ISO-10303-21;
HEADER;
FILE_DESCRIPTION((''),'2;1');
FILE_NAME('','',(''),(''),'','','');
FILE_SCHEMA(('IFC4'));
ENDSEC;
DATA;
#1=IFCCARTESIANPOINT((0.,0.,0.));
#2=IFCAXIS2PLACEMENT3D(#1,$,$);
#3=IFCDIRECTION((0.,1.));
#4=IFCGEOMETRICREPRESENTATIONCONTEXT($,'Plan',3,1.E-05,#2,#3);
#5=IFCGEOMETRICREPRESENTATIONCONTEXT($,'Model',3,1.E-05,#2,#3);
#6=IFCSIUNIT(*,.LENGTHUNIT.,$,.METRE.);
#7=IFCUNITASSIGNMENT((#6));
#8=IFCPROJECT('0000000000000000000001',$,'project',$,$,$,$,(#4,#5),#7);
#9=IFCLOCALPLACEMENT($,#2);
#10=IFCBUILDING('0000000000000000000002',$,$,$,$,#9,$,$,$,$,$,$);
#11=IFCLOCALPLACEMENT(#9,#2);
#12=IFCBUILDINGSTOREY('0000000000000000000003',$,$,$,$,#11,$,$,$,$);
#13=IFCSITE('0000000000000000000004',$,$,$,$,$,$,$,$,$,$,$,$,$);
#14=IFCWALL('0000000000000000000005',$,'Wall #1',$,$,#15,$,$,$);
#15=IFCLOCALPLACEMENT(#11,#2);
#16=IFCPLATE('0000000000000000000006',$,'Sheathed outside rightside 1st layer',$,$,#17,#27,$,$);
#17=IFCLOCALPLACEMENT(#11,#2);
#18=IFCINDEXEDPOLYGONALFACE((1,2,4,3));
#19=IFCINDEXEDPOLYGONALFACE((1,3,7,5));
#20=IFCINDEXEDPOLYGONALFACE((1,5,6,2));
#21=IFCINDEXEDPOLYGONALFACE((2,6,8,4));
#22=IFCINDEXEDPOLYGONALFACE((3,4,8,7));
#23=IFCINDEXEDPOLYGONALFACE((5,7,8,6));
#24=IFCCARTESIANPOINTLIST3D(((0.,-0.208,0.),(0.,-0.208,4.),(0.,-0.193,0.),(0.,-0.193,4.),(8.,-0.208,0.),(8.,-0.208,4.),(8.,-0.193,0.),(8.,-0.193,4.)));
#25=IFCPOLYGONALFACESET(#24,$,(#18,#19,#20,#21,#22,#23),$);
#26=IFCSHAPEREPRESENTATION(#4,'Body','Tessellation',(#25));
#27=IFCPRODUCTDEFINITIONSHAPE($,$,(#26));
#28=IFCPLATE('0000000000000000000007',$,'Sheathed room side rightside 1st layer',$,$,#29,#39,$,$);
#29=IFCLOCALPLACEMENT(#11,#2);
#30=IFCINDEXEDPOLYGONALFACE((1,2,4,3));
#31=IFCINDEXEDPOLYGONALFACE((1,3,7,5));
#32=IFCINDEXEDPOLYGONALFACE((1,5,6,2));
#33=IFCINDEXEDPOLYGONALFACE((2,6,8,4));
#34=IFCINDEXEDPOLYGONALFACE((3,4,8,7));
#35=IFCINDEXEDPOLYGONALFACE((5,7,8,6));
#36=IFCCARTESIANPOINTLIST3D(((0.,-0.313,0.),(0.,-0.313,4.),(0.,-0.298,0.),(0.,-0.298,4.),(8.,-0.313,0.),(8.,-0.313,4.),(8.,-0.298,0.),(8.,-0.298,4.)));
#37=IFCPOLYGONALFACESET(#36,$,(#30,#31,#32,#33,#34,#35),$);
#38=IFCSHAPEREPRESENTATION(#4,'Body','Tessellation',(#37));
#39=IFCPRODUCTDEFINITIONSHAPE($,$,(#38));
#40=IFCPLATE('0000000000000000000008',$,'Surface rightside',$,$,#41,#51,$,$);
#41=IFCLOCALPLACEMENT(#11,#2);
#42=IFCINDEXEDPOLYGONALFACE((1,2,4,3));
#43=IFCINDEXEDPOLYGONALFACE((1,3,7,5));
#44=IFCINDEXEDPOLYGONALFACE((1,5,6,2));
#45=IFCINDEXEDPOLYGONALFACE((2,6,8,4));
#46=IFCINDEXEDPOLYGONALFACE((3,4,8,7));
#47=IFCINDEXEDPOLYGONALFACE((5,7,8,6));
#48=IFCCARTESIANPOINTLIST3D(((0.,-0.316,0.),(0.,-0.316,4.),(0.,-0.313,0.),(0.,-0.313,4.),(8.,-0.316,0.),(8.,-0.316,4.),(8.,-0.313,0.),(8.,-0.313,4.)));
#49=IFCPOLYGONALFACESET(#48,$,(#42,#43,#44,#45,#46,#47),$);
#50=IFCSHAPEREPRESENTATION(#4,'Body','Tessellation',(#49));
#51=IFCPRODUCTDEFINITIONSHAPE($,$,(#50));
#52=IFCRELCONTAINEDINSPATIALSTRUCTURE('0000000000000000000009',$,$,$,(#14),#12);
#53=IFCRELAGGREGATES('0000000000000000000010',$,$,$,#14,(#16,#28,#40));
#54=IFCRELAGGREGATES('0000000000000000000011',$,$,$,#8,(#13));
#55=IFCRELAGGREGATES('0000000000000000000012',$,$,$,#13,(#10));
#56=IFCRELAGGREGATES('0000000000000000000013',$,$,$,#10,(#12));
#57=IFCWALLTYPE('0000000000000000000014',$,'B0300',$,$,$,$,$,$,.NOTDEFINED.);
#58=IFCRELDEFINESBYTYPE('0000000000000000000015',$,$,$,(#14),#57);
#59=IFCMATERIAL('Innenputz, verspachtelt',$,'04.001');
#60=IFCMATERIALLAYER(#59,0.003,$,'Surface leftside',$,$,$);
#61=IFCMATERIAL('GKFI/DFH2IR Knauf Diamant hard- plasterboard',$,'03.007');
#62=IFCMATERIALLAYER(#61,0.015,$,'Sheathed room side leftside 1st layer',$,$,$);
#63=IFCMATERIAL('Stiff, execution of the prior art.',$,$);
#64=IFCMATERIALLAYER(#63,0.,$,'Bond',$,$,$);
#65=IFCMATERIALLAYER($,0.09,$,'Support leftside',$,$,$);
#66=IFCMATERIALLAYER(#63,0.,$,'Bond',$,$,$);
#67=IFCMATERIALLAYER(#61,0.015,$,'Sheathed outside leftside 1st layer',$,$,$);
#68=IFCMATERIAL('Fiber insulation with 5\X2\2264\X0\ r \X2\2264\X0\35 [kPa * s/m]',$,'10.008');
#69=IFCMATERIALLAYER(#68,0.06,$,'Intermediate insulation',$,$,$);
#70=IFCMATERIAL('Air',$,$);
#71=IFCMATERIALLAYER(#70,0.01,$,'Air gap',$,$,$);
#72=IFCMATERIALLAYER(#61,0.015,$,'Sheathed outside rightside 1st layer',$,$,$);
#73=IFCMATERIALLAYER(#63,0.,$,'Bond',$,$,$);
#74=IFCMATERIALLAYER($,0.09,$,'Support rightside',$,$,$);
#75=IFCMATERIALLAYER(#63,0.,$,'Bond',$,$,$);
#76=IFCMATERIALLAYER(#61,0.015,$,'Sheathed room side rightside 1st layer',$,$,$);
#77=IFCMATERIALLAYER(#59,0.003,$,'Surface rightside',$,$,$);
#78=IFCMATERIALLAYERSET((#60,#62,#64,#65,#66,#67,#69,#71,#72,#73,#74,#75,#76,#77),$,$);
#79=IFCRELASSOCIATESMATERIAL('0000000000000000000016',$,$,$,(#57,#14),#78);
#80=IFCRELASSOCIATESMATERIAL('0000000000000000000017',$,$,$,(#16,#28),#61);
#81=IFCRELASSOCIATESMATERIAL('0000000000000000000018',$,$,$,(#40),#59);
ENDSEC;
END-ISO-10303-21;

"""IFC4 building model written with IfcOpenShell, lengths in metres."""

from ifc_helpers import new_model, si_unit, direction, frame, frame_2d, origin, place, context, project, spatial, rectangle, extrude, material, layer, layer_set, type_object, element, aggregate, save


model = new_model("IFC4")

# Units and contexts
plan_context = context("Plan", 3, precision=1e-05, world=origin(), true_north=direction((0.0, 1.0)))
model_context = context("Model", 3, precision=1e-05, world=origin(), true_north=direction((0.0, 1.0)))
ifc_project = project(units=[si_unit("LENGTHUNIT", "METRE")], contexts=[plan_context, model_context])

# Site, building, storey
site = spatial("IfcSite", under=ifc_project)
building_placement = place(None, origin())
building = spatial("IfcBuilding", under=site, at=building_placement)
storey_placement = place(building_placement, origin())
storey = spatial("IfcBuildingStorey", under=building, at=storey_placement)

# Wall, plates
ifc_material_1 = material(Name="Innenputz, verspachtelt", Category="04.001")
ifc_layer_1 = layer(ifc_material_1, 0.003, Name="Surface leftside")
ifc_material_2 = material(Name="GKFI/DFH2IR Knauf Diamant hard- plasterboard", Category="03.007")
ifc_layer_2 = layer(ifc_material_2, 0.015, Name="Sheathed room side leftside 1st layer")
ifc_material_3 = material(Name="Stiff, execution of the prior art.")
ifc_layer_3 = layer(ifc_material_3, 0.0, Name="Bond")
ifc_layer_4 = layer(None, 0.09, Name="Support leftside")
ifc_layer_5 = layer(ifc_material_3, 0.0, Name="Bond")
ifc_layer_6 = layer(ifc_material_2, 0.015, Name="Sheathed outside leftside 1st layer")
ifc_material_4 = material(Name="Fiber insulation with 5≤ r ≤35 [kPa * s/m]", Category="10.008")
ifc_layer_7 = layer(ifc_material_4, 0.06, Name="Intermediate insulation")
ifc_material_5 = material(Name="Air")
ifc_layer_8 = layer(ifc_material_5, 0.01, Name="Air gap")
ifc_layer_9 = layer(ifc_material_2, 0.015, Name="Sheathed outside rightside 1st layer")
ifc_layer_10 = layer(ifc_material_3, 0.0, Name="Bond")
ifc_layer_11 = layer(None, 0.09, Name="Support rightside")
ifc_layer_12 = layer(ifc_material_3, 0.0, Name="Bond")
ifc_layer_13 = layer(ifc_material_2, 0.015, Name="Sheathed room side rightside 1st layer")
ifc_layer_14 = layer(ifc_material_1, 0.003, Name="Surface rightside")
ifc_layer_set = layer_set([ifc_layer_1, ifc_layer_2, ifc_layer_3, ifc_layer_4, ifc_layer_5, ifc_layer_6, ifc_layer_7, ifc_layer_8, ifc_layer_9, ifc_layer_10, ifc_layer_11, ifc_layer_12, ifc_layer_13, ifc_layer_14])
wall_type = type_object("IfcWallType", Name="B0300", PredefinedType="NOTDEFINED", material=ifc_layer_set)
wall_placement = place(None, frame((0.0, 0.0, 0.0), z_axis=(0.0, -1.0, 0.0), x_axis=(1.0, 0.0, 0.0)))
wall = element("IfcWall", 1, at=wall_placement, inside=storey, type_object=wall_type, material=ifc_layer_set, Name="Wall #1")
plate_1_placement = place(wall_placement, origin())
plate_1 = element("IfcPlate", 2, at=plate_1_placement, material=ifc_material_2, Name="Sheathed outside rightside 1st layer", context=plan_context, shape_type="SweptSolid", body=[
    extrude(rectangle(XDim=8.0, YDim=4.0, at=frame_2d((4.0, 2.0), x_axis=(1.0, 0.0))), frame((0.0, 0.0, 0.193), z_axis=(0.0, 0.0, 1.0), x_axis=(1.0, 0.0, 0.0)), (0.0, 0.0, 1.0), 0.015),
])
plate_2_placement = place(wall_placement, origin())
plate_2 = element("IfcPlate", 3, at=plate_2_placement, material=ifc_material_2, Name="Sheathed room side rightside 1st layer", context=plan_context, shape_type="SweptSolid", body=[
    extrude(rectangle(XDim=8.0, YDim=4.0, at=frame_2d((4.0, 2.0), x_axis=(1.0, 0.0))), frame((0.0, 0.0, 0.298), z_axis=(0.0, 0.0, 1.0), x_axis=(1.0, 0.0, 0.0)), (0.0, 0.0, 1.0), 0.015),
])
plate_3_placement = place(wall_placement, origin())
plate_3 = element("IfcPlate", 4, at=plate_3_placement, material=ifc_material_1, Name="Surface rightside", context=plan_context, shape_type="SweptSolid", body=[
    extrude(rectangle(XDim=8.0, YDim=4.0, at=frame_2d((4.0, 2.0), x_axis=(1.0, 0.0))), frame((0.0, 0.0, 0.313), z_axis=(0.0, 0.0, 1.0), x_axis=(1.0, 0.0, 0.0)), (0.0, 0.0, 1.0), 0.003),
])
aggregate(wall, [plate_1, plate_2, plate_3])

save(model, "model.ifc")
